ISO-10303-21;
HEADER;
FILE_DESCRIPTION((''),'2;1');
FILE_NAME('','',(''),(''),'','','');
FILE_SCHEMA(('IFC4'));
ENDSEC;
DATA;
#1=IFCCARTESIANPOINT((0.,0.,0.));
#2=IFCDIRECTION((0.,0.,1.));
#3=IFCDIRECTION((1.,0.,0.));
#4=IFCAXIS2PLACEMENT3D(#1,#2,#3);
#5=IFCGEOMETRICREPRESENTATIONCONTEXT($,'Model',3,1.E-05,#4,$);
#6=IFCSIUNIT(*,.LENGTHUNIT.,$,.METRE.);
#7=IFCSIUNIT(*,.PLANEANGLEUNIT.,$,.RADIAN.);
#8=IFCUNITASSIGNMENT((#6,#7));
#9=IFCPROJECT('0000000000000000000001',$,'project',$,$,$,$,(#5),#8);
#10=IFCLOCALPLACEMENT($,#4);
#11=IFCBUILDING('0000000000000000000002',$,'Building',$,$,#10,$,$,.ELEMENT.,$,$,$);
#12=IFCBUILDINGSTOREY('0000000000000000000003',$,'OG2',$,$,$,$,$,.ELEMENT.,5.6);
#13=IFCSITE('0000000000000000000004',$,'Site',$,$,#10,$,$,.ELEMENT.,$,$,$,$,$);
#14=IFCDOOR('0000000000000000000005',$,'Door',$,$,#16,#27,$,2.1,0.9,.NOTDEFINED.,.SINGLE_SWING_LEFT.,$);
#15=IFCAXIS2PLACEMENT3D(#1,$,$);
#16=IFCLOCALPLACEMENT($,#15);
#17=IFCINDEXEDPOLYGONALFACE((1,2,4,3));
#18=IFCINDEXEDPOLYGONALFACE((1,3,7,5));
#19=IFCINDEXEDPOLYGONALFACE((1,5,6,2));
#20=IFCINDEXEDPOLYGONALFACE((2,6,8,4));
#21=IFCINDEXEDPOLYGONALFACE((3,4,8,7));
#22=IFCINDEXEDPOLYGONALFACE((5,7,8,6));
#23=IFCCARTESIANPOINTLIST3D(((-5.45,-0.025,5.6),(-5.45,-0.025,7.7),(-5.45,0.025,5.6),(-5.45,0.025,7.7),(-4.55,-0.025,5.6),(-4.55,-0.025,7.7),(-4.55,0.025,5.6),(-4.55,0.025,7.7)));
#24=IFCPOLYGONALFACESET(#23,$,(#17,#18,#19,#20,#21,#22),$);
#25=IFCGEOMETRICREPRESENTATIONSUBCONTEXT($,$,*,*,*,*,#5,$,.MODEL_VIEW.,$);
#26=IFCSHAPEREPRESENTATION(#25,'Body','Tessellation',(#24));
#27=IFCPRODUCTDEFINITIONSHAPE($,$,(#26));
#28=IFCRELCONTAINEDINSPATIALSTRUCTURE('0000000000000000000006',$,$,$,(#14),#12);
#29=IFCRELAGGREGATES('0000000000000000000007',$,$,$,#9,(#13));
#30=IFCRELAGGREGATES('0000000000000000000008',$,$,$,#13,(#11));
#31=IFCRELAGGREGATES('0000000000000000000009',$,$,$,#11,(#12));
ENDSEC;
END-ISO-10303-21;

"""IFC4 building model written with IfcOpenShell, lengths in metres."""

from ifc_helpers import new_model, si_unit, frame, origin, origin_with_axes, origin_2d, place, context, subcontext, project, spatial, rectangle, extrude, element, save


model = new_model("IFC4")

# Units and contexts
model_context = context("Model", 3, precision=1e-05, world=origin_with_axes())
sub_context = subcontext(model_context, None, None, "MODEL_VIEW")
ifc_project = project(units=[si_unit("LENGTHUNIT", "METRE"), si_unit("PLANEANGLEUNIT", "RADIAN")], contexts=[model_context])

# Site, building, storey
placement_1 = place(None, origin_with_axes())
site = spatial("IfcSite", under=ifc_project, at=placement_1, Name="Site", CompositionType="ELEMENT")
building = spatial("IfcBuilding", under=site, at=placement_1, Name="Building", CompositionType="ELEMENT")
storey = spatial("IfcBuildingStorey", under=building, Name="OG2", CompositionType="ELEMENT", Elevation=5.6)

# Door
placement_2 = place(None, origin_with_axes())
door_placement = place(placement_2, frame((-5.0, 0.0, 5.6)))
element("IfcDoor", 1, at=door_placement, inside=storey, Name="Door", OperationType="SINGLE_SWING_LEFT", OverallHeight=2.1, OverallWidth=0.9, PredefinedType="NOTDEFINED", context=sub_context, shape_type="SweptSolid", body=[
    extrude(rectangle(XDim=0.9, YDim=0.05, at=origin_2d()), origin(), (0.0, 0.0, 1.0), 2.1),
])

save(model, "model.ifc")
